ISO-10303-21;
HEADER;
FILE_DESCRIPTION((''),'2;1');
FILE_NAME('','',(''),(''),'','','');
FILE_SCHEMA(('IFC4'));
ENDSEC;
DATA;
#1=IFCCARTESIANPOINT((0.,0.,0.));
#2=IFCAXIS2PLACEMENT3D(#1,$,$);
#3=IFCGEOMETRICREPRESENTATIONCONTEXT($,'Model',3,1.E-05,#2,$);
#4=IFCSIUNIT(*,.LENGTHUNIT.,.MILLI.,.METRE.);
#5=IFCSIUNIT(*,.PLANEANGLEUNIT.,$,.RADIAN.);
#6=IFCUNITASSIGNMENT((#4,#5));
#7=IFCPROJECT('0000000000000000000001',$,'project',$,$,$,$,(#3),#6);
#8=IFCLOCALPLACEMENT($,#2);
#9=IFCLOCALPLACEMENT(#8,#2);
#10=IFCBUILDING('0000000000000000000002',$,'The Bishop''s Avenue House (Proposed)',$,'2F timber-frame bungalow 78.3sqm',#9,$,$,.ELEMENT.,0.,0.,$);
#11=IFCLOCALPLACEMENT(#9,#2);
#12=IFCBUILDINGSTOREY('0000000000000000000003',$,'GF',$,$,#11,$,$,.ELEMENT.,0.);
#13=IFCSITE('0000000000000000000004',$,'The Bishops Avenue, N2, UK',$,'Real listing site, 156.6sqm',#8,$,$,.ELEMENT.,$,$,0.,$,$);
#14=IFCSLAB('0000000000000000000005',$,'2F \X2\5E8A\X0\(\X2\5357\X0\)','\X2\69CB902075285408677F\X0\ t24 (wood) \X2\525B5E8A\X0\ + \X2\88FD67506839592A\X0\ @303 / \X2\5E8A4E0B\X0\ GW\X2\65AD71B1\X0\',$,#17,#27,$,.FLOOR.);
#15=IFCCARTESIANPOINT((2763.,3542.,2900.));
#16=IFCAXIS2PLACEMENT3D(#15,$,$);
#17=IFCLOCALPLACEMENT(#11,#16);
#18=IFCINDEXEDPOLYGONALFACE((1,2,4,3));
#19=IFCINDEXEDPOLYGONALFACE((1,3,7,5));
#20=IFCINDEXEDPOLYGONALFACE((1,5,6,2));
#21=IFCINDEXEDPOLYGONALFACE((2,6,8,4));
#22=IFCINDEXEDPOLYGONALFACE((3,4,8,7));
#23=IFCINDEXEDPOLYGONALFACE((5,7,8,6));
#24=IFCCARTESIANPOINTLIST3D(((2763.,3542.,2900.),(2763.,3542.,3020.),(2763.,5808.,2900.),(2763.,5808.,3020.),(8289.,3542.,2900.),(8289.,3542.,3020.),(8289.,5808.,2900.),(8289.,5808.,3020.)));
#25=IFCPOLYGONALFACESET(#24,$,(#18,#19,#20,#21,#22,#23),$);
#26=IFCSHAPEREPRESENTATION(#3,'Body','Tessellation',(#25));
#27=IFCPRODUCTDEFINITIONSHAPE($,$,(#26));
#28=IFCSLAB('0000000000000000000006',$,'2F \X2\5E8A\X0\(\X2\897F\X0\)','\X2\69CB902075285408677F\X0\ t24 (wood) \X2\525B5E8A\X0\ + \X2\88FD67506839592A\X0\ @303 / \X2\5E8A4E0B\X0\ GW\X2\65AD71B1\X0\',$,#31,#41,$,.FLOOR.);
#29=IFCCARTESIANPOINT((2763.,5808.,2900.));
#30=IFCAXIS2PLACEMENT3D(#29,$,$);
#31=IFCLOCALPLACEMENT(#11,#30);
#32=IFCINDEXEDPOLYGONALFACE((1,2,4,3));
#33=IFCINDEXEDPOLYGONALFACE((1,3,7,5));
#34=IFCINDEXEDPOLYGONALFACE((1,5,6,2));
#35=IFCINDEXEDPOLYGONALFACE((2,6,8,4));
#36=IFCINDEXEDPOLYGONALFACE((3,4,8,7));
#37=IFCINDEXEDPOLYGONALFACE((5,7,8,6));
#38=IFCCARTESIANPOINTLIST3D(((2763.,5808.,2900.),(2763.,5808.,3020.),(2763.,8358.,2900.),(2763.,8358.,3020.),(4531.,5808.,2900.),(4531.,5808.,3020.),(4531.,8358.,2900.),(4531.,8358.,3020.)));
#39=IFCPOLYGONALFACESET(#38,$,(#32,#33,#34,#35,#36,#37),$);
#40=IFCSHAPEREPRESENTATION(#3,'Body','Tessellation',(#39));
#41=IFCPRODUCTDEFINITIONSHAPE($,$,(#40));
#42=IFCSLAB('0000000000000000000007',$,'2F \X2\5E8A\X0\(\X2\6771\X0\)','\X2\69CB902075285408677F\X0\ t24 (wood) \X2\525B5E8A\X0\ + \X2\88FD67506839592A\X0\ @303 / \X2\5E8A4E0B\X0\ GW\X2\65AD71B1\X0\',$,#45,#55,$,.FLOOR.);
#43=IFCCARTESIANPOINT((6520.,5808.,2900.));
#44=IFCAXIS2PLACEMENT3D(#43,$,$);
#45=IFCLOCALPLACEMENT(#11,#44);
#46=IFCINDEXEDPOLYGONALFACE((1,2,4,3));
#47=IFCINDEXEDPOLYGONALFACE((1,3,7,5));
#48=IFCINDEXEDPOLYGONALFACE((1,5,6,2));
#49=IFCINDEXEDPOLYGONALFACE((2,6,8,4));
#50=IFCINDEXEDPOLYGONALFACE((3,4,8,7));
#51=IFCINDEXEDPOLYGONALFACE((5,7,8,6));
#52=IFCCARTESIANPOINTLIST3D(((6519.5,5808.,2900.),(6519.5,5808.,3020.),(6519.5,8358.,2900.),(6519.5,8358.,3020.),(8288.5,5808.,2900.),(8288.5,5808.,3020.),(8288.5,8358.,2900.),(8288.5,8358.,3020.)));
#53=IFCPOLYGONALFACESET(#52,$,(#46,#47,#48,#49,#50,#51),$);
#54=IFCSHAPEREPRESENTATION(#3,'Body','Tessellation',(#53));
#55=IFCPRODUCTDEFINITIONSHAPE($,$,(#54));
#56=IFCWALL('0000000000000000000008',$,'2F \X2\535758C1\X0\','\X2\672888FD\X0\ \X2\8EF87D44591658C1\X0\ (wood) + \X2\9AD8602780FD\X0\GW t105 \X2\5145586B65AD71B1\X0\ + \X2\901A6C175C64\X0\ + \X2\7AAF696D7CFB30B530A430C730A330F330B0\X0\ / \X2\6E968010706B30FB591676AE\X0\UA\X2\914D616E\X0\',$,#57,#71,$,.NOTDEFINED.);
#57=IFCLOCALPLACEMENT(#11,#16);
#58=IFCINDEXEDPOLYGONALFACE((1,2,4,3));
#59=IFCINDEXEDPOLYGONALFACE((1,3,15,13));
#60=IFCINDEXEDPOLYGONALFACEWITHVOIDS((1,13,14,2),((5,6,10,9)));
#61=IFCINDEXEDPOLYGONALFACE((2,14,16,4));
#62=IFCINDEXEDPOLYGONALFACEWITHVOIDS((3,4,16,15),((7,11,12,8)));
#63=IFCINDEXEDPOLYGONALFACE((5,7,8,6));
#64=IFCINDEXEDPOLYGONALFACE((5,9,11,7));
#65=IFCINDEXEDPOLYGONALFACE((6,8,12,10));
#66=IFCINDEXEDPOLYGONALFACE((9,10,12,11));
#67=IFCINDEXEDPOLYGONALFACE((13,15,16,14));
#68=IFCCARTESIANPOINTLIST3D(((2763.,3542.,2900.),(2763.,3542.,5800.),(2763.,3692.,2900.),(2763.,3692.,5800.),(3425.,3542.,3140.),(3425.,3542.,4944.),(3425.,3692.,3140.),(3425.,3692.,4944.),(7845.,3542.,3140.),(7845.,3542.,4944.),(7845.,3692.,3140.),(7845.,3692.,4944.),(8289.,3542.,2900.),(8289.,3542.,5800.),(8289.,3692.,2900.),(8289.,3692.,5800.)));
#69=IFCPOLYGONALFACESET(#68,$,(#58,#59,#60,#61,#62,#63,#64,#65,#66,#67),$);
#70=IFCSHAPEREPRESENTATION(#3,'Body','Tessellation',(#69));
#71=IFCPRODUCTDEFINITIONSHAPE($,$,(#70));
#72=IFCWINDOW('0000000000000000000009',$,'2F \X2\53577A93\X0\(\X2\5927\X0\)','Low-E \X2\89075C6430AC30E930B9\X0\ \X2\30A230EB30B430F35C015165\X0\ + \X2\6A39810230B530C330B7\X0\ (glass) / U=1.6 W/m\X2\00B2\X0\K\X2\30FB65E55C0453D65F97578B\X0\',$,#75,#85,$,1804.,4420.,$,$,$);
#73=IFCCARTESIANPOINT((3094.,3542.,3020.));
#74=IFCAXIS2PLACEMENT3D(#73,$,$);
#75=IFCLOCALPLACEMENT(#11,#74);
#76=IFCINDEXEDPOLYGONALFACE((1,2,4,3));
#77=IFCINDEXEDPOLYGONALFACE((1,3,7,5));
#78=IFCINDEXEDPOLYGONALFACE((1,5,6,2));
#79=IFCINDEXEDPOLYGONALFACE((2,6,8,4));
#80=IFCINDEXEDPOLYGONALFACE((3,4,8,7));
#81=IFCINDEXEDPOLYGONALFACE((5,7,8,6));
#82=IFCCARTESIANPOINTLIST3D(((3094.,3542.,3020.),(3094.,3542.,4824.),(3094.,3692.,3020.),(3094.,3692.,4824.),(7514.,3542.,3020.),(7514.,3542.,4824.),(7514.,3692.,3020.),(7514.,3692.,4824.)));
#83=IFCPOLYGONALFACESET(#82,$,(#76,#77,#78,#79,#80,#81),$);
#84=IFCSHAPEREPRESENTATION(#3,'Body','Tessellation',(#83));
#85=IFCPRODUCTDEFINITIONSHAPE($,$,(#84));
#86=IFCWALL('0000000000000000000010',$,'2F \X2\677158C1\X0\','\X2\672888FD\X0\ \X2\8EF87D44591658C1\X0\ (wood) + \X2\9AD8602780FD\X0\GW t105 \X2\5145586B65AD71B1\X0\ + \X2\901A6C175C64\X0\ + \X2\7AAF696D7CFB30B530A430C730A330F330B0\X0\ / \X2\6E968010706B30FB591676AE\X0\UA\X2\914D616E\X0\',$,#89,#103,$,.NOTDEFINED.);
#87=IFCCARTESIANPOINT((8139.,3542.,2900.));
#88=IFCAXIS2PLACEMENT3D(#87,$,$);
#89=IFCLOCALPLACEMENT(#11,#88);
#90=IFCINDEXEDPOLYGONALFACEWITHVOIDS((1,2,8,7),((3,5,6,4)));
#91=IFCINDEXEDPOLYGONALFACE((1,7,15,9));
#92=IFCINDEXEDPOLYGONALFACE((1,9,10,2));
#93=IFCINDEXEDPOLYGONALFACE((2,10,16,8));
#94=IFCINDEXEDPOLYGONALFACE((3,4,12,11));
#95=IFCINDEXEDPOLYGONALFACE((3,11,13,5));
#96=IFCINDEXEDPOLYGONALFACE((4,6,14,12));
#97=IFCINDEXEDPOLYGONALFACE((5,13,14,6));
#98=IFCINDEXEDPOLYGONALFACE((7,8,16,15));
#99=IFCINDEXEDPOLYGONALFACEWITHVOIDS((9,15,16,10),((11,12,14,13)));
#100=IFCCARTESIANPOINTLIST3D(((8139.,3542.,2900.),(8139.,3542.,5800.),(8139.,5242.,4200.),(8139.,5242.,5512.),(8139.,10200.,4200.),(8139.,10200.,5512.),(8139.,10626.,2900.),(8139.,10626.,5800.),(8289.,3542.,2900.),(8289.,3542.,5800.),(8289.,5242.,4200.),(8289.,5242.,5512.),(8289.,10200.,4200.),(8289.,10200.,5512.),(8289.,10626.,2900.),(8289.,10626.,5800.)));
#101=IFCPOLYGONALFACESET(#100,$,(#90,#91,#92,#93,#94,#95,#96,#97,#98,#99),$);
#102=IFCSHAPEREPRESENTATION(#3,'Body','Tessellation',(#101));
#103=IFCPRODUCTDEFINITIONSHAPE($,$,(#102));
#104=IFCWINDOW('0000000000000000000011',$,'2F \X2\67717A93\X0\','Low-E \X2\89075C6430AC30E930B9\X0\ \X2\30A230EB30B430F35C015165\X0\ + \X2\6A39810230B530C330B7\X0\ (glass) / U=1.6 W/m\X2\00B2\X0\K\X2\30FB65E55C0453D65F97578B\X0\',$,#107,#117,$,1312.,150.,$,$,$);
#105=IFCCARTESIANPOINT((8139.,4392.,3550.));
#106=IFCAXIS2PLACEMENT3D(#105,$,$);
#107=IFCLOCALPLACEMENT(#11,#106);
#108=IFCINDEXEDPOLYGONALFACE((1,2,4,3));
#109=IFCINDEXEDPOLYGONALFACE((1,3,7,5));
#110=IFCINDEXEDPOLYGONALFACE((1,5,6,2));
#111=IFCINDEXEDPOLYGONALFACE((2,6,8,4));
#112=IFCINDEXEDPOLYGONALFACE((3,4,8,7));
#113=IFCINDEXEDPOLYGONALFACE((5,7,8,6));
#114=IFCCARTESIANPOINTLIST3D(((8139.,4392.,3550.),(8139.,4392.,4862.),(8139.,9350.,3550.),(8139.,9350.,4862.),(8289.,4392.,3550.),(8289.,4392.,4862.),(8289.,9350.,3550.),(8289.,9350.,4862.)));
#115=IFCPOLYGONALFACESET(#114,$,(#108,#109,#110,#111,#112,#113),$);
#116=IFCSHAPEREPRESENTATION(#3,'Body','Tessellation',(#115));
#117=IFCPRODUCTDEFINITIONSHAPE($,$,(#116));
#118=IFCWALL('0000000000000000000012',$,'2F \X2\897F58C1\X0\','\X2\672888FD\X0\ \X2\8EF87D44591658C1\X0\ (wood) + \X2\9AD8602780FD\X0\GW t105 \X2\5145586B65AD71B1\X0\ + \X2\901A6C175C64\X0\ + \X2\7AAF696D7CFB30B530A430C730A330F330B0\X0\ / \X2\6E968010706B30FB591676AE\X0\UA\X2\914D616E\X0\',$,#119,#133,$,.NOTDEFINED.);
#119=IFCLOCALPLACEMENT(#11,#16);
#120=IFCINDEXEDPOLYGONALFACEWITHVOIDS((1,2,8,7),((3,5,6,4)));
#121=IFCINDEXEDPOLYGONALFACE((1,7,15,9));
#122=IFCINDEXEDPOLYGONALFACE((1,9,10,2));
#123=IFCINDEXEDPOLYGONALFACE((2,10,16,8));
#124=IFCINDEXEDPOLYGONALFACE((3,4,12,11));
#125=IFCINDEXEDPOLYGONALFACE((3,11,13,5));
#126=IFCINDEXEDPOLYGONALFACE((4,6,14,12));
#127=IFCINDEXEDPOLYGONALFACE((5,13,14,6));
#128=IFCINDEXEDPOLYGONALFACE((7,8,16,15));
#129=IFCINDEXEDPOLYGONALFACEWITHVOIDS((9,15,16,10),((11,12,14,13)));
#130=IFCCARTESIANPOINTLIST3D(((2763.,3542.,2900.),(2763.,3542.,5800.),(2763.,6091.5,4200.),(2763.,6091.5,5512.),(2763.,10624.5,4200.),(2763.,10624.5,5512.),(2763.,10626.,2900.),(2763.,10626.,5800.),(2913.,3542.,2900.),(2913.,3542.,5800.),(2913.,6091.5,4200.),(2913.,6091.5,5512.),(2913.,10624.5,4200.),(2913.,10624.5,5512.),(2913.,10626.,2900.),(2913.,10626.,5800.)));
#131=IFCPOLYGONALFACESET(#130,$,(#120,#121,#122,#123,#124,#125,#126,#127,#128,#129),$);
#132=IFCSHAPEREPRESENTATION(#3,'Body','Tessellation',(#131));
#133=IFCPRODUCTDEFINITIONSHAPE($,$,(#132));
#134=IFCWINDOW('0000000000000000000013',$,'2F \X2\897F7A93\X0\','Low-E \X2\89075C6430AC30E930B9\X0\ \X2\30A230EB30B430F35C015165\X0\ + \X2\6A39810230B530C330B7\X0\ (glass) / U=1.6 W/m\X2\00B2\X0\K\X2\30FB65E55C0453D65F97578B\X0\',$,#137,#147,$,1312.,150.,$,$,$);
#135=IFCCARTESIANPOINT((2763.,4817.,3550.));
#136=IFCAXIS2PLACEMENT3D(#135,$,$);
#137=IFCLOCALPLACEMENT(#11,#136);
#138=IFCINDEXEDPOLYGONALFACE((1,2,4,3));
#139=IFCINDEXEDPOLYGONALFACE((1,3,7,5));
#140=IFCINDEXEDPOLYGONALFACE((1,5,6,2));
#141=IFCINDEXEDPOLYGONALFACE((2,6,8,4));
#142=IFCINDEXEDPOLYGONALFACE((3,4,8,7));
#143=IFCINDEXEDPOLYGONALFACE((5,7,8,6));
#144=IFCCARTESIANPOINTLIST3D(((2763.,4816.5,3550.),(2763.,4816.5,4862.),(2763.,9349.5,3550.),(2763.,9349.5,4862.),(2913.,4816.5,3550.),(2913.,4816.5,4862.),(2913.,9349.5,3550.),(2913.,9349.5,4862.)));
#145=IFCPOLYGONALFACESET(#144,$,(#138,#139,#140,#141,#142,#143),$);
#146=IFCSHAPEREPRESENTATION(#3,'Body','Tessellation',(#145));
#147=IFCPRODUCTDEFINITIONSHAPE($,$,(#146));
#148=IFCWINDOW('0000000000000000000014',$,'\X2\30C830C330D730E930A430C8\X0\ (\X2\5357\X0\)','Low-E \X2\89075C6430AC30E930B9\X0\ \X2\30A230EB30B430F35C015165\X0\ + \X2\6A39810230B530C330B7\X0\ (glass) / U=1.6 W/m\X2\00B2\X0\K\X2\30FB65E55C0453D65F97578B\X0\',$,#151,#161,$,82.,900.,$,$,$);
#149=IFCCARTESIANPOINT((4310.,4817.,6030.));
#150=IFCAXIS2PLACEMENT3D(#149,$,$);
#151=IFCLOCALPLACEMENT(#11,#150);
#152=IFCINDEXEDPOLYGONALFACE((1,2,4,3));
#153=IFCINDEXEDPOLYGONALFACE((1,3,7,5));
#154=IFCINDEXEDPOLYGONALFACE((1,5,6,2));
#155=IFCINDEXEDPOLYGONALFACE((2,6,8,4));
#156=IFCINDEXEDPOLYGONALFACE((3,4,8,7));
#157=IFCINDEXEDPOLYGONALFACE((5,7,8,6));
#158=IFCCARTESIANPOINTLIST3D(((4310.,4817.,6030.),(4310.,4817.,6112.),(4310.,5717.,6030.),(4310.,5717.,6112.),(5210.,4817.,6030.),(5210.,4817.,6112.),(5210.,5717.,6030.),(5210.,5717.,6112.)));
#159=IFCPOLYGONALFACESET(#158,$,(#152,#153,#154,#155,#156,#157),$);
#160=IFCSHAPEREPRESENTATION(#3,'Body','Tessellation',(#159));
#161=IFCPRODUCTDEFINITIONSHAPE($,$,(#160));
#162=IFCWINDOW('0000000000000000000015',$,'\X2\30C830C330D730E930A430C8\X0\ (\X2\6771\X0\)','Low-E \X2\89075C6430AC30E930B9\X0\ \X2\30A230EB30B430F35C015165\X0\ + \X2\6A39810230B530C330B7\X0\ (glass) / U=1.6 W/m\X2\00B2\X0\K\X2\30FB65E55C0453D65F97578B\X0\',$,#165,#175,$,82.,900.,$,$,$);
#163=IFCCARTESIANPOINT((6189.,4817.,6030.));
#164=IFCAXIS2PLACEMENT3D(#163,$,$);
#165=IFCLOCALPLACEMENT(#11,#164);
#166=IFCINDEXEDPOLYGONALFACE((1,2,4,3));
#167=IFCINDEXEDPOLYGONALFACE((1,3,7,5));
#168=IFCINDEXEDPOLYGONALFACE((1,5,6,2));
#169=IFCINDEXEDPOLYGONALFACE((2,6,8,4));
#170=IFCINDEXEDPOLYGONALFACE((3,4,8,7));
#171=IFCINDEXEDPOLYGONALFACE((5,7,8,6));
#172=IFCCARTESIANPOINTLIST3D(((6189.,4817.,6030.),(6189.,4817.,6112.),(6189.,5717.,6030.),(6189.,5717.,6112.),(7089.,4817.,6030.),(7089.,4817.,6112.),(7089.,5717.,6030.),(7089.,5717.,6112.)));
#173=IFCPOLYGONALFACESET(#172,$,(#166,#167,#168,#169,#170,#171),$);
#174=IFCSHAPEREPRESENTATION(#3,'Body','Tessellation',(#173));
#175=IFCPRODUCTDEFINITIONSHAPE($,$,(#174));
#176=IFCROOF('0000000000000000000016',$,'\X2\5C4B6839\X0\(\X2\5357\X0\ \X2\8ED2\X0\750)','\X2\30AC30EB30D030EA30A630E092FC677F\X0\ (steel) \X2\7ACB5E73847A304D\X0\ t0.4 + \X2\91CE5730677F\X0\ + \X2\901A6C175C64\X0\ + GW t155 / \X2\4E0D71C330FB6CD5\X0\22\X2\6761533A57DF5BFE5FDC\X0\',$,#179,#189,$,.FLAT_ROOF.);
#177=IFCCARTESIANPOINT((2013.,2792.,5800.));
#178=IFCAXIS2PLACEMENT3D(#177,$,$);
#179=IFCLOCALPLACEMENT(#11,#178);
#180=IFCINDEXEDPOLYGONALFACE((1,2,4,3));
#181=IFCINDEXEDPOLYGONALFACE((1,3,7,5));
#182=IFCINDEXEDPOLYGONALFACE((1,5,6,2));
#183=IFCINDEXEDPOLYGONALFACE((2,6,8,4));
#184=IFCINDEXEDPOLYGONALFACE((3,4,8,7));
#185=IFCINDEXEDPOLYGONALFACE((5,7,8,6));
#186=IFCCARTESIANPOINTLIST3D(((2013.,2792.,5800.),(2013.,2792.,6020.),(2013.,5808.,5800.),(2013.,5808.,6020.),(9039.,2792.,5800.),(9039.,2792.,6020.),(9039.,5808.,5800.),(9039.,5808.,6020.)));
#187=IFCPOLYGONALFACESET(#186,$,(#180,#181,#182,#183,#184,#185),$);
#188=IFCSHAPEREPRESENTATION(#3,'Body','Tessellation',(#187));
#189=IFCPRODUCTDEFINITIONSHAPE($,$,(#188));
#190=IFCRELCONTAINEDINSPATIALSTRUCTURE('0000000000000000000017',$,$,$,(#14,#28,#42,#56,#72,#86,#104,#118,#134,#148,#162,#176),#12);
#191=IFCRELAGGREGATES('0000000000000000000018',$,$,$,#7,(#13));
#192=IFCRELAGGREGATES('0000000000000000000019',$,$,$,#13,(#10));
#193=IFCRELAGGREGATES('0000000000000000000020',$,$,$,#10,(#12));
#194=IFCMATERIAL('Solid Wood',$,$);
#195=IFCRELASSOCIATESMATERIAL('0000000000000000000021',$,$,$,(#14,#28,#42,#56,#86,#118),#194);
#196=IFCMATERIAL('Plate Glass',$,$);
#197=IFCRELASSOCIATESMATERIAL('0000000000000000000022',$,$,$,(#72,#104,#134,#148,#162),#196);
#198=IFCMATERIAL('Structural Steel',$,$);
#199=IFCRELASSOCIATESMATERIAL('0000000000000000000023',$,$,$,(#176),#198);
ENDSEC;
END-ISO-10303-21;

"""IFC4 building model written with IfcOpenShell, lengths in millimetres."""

from ifc_helpers import new_model, si_unit, frame, frame_2d, origin, place, context, project, spatial, rectangle, extrude, material, element, fill, save


model = new_model("IFC4")

# Units and contexts
model_context = context("Model", 3, precision=1e-05, world=origin())
ifc_project = project(units=[si_unit("LENGTHUNIT", "METRE", prefix="MILLI"), si_unit("PLANEANGLEUNIT", "RADIAN")], contexts=[model_context])

# Site, building, storey
site_placement = place(None, origin())
site = spatial("IfcSite", under=ifc_project, at=site_placement, Name="The Bishops Avenue, N2, UK", ObjectType="Real listing site, 156.6sqm", CompositionType="ELEMENT", RefElevation=0.0)
building_placement = place(site_placement, origin())
building = spatial("IfcBuilding", under=site, at=building_placement, Name="The Bishop's Avenue House (Proposed)", ObjectType="2F timber-frame bungalow 78.3sqm", CompositionType="ELEMENT", ElevationOfRefHeight=0.0, ElevationOfTerrain=0.0)
storey_placement = place(building_placement, origin())
storey = spatial("IfcBuildingStorey", under=building, at=storey_placement, Name="GF", CompositionType="ELEMENT", Elevation=0.0)

# Slabs
ifc_material_1 = material(Name="Solid Wood")
slab_1_placement = place(storey_placement, frame((2763.0, 3542.0, 2900.0)))
element("IfcSlab", 1, at=slab_1_placement, inside=storey, material=ifc_material_1, Name="2F 床(南)", Description="構造用合板 t24 (wood) 剛床 + 製材根太 @303 / 床下 GW断熱", PredefinedType="FLOOR", context=model_context, shape_type="SweptSolid", body=[
    extrude(rectangle(XDim=5526.0, YDim=2266.0, at=frame_2d((2763.0, 1133.0))), frame((2763.0, 3542.0, 2900.0)), (0.0, 0.0, 1.0), 120.0),
])
slab_2_placement = place(storey_placement, frame((2763.0, 5808.0, 2900.0)))
element("IfcSlab", 2, at=slab_2_placement, inside=storey, material=ifc_material_1, Name="2F 床(西)", Description="構造用合板 t24 (wood) 剛床 + 製材根太 @303 / 床下 GW断熱", PredefinedType="FLOOR", context=model_context, shape_type="SweptSolid", body=[
    extrude(rectangle(XDim=1768.0, YDim=2550.0, at=frame_2d((884.0, 1275.0))), frame((2763.0, 5808.0, 2900.0)), (0.0, 0.0, 1.0), 120.0),
])
slab_3_placement = place(storey_placement, frame((6520.0, 5808.0, 2900.0)))
element("IfcSlab", 3, at=slab_3_placement, inside=storey, material=ifc_material_1, Name="2F 床(東)", Description="構造用合板 t24 (wood) 剛床 + 製材根太 @303 / 床下 GW断熱", PredefinedType="FLOOR", context=model_context, shape_type="SweptSolid", body=[
    extrude(rectangle(XDim=1769.0, YDim=2550.0, at=frame_2d((884.0, 1275.0))), frame((6520.0, 5808.0, 2900.0)), (0.0, 0.0, 1.0), 120.0),
])

# Walls, openings, windows
wall_1_placement = place(storey_placement, frame((2763.0, 3542.0, 2900.0)))
wall_1 = element("IfcWall", 4, at=wall_1_placement, inside=storey, material=ifc_material_1, Name="2F 南壁", Description="木製 軸組外壁 (wood) + 高性能GW t105 充填断熱 + 通気層 + 窯業系サイディング / 準耐火・外皮UA配慮", PredefinedType="NOTDEFINED", context=model_context, shape_type="SweptSolid", body=[
    extrude(rectangle(XDim=5526.0, YDim=150.0, at=frame_2d((2763.0, 75.0))), frame((2763.0, 3542.0, 2900.0)), (0.0, 0.0, 1.0), 2900.0),
])
opening_1_placement = place(storey_placement, frame((3094.0, 3542.0, 3020.0)))
opening_1 = element("IfcOpeningElement", 5, at=opening_1_placement, cuts=wall_1, PredefinedType="NOTDEFINED", context=model_context, shape_type="SweptSolid", body=[
    extrude(rectangle(XDim=4420.0, YDim=150.0, at=frame_2d((2210.0, 75.0))), frame((3094.0, 3542.0, 3020.0)), (0.0, 0.0, 1.0), 1804.0),
])
ifc_material_2 = material(Name="Plate Glass")
window_1_placement = place(storey_placement, frame((3094.0, 3542.0, 3020.0)))
window_1 = element("IfcWindow", 6, at=window_1_placement, inside=storey, material=ifc_material_2, Name="2F 南窓(大)", Description="Low-E 複層ガラス アルゴン封入 + 樹脂サッシ (glass) / U=1.6 W/m²K・日射取得型", OverallHeight=1804.0, OverallWidth=4420.0, context=model_context, shape_type="SweptSolid", body=[
    extrude(rectangle(XDim=4420.0, YDim=150.0, at=frame_2d((2210.0, 75.0))), frame((3094.0, 3542.0, 3020.0)), (0.0, 0.0, 1.0), 1804.0),
])
fill(opening_1, window_1)
wall_2_placement = place(storey_placement, frame((8139.0, 3542.0, 2900.0)))
wall_2 = element("IfcWall", 7, at=wall_2_placement, inside=storey, material=ifc_material_1, Name="2F 東壁", Description="木製 軸組外壁 (wood) + 高性能GW t105 充填断熱 + 通気層 + 窯業系サイディング / 準耐火・外皮UA配慮", PredefinedType="NOTDEFINED", context=model_context, shape_type="SweptSolid", body=[
    extrude(rectangle(XDim=150.0, YDim=7084.0, at=frame_2d((75.0, 3542.0))), frame((8139.0, 3542.0, 2900.0)), (0.0, 0.0, 1.0), 2900.0),
])
opening_2_placement = place(storey_placement, frame((8139.0, 4392.0, 3550.0)))
opening_2 = element("IfcOpeningElement", 8, at=opening_2_placement, cuts=wall_2, PredefinedType="NOTDEFINED", context=model_context, shape_type="SweptSolid", body=[
    extrude(rectangle(XDim=150.0, YDim=4958.0, at=frame_2d((75.0, 2479.0))), frame((8139.0, 4392.0, 3550.0)), (0.0, 0.0, 1.0), 1312.0),
])
window_2_placement = place(storey_placement, frame((8139.0, 4392.0, 3550.0)))
window_2 = element("IfcWindow", 9, at=window_2_placement, inside=storey, material=ifc_material_2, Name="2F 東窓", Description="Low-E 複層ガラス アルゴン封入 + 樹脂サッシ (glass) / U=1.6 W/m²K・日射取得型", OverallHeight=1312.0, OverallWidth=150.0, context=model_context, shape_type="SweptSolid", body=[
    extrude(rectangle(XDim=150.0, YDim=4958.0, at=frame_2d((75.0, 2479.0))), frame((8139.0, 4392.0, 3550.0)), (0.0, 0.0, 1.0), 1312.0),
])
fill(opening_2, window_2)
wall_3_placement = place(storey_placement, frame((2763.0, 3542.0, 2900.0)))
wall_3 = element("IfcWall", 10, at=wall_3_placement, inside=storey, material=ifc_material_1, Name="2F 西壁", Description="木製 軸組外壁 (wood) + 高性能GW t105 充填断熱 + 通気層 + 窯業系サイディング / 準耐火・外皮UA配慮", PredefinedType="NOTDEFINED", context=model_context, shape_type="SweptSolid", body=[
    extrude(rectangle(XDim=150.0, YDim=7084.0, at=frame_2d((75.0, 3542.0))), frame((2763.0, 3542.0, 2900.0)), (0.0, 0.0, 1.0), 2900.0),
])
opening_3_placement = place(storey_placement, frame((2763.0, 4817.0, 3550.0)))
opening_3 = element("IfcOpeningElement", 11, at=opening_3_placement, cuts=wall_3, PredefinedType="NOTDEFINED", context=model_context, shape_type="SweptSolid", body=[
    extrude(rectangle(XDim=150.0, YDim=4533.0, at=frame_2d((75.0, 2266.0))), frame((2763.0, 4817.0, 3550.0)), (0.0, 0.0, 1.0), 1312.0),
])
window_3_placement = place(storey_placement, frame((2763.0, 4817.0, 3550.0)))
window_3 = element("IfcWindow", 12, at=window_3_placement, inside=storey, material=ifc_material_2, Name="2F 西窓", Description="Low-E 複層ガラス アルゴン封入 + 樹脂サッシ (glass) / U=1.6 W/m²K・日射取得型", OverallHeight=1312.0, OverallWidth=150.0, context=model_context, shape_type="SweptSolid", body=[
    extrude(rectangle(XDim=150.0, YDim=4533.0, at=frame_2d((75.0, 2266.0))), frame((2763.0, 4817.0, 3550.0)), (0.0, 0.0, 1.0), 1312.0),
])
fill(opening_3, window_3)

# Windows
window_4_placement = place(storey_placement, frame((4310.0, 4817.0, 6030.0)))
element("IfcWindow", 13, at=window_4_placement, inside=storey, material=ifc_material_2, Name="トップライト (南)", Description="Low-E 複層ガラス アルゴン封入 + 樹脂サッシ (glass) / U=1.6 W/m²K・日射取得型", OverallHeight=82.0, OverallWidth=900.0, context=model_context, shape_type="SweptSolid", body=[
    extrude(rectangle(XDim=900.0, YDim=900.0, at=frame_2d((450.0, 450.0))), frame((4310.0, 4817.0, 6030.0)), (0.0, 0.0, 1.0), 82.0),
])
window_5_placement = place(storey_placement, frame((6189.0, 4817.0, 6030.0)))
element("IfcWindow", 14, at=window_5_placement, inside=storey, material=ifc_material_2, Name="トップライト (東)", Description="Low-E 複層ガラス アルゴン封入 + 樹脂サッシ (glass) / U=1.6 W/m²K・日射取得型", OverallHeight=82.0, OverallWidth=900.0, context=model_context, shape_type="SweptSolid", body=[
    extrude(rectangle(XDim=900.0, YDim=900.0, at=frame_2d((450.0, 450.0))), frame((6189.0, 4817.0, 6030.0)), (0.0, 0.0, 1.0), 82.0),
])

# Roof
ifc_material_3 = material(Name="Structural Steel")
roof_1_placement = place(storey_placement, frame((2013.0, 2792.0, 5800.0)))
element("IfcRoof", 15, at=roof_1_placement, inside=storey, material=ifc_material_3, Name="屋根(南 軒750)", Description="ガルバリウム鋼板 (steel) 立平葺き t0.4 + 野地板 + 通気層 + GW t155 / 不燃・法22条区域対応", PredefinedType="FLAT_ROOF", context=model_context, shape_type="SweptSolid", body=[
    extrude(rectangle(XDim=7026.0, YDim=3016.0, at=frame_2d((3513.0, 1508.0))), frame((2013.0, 2792.0, 5800.0)), (0.0, 0.0, 1.0), 220.0),
])

save(model, "model.ifc")
